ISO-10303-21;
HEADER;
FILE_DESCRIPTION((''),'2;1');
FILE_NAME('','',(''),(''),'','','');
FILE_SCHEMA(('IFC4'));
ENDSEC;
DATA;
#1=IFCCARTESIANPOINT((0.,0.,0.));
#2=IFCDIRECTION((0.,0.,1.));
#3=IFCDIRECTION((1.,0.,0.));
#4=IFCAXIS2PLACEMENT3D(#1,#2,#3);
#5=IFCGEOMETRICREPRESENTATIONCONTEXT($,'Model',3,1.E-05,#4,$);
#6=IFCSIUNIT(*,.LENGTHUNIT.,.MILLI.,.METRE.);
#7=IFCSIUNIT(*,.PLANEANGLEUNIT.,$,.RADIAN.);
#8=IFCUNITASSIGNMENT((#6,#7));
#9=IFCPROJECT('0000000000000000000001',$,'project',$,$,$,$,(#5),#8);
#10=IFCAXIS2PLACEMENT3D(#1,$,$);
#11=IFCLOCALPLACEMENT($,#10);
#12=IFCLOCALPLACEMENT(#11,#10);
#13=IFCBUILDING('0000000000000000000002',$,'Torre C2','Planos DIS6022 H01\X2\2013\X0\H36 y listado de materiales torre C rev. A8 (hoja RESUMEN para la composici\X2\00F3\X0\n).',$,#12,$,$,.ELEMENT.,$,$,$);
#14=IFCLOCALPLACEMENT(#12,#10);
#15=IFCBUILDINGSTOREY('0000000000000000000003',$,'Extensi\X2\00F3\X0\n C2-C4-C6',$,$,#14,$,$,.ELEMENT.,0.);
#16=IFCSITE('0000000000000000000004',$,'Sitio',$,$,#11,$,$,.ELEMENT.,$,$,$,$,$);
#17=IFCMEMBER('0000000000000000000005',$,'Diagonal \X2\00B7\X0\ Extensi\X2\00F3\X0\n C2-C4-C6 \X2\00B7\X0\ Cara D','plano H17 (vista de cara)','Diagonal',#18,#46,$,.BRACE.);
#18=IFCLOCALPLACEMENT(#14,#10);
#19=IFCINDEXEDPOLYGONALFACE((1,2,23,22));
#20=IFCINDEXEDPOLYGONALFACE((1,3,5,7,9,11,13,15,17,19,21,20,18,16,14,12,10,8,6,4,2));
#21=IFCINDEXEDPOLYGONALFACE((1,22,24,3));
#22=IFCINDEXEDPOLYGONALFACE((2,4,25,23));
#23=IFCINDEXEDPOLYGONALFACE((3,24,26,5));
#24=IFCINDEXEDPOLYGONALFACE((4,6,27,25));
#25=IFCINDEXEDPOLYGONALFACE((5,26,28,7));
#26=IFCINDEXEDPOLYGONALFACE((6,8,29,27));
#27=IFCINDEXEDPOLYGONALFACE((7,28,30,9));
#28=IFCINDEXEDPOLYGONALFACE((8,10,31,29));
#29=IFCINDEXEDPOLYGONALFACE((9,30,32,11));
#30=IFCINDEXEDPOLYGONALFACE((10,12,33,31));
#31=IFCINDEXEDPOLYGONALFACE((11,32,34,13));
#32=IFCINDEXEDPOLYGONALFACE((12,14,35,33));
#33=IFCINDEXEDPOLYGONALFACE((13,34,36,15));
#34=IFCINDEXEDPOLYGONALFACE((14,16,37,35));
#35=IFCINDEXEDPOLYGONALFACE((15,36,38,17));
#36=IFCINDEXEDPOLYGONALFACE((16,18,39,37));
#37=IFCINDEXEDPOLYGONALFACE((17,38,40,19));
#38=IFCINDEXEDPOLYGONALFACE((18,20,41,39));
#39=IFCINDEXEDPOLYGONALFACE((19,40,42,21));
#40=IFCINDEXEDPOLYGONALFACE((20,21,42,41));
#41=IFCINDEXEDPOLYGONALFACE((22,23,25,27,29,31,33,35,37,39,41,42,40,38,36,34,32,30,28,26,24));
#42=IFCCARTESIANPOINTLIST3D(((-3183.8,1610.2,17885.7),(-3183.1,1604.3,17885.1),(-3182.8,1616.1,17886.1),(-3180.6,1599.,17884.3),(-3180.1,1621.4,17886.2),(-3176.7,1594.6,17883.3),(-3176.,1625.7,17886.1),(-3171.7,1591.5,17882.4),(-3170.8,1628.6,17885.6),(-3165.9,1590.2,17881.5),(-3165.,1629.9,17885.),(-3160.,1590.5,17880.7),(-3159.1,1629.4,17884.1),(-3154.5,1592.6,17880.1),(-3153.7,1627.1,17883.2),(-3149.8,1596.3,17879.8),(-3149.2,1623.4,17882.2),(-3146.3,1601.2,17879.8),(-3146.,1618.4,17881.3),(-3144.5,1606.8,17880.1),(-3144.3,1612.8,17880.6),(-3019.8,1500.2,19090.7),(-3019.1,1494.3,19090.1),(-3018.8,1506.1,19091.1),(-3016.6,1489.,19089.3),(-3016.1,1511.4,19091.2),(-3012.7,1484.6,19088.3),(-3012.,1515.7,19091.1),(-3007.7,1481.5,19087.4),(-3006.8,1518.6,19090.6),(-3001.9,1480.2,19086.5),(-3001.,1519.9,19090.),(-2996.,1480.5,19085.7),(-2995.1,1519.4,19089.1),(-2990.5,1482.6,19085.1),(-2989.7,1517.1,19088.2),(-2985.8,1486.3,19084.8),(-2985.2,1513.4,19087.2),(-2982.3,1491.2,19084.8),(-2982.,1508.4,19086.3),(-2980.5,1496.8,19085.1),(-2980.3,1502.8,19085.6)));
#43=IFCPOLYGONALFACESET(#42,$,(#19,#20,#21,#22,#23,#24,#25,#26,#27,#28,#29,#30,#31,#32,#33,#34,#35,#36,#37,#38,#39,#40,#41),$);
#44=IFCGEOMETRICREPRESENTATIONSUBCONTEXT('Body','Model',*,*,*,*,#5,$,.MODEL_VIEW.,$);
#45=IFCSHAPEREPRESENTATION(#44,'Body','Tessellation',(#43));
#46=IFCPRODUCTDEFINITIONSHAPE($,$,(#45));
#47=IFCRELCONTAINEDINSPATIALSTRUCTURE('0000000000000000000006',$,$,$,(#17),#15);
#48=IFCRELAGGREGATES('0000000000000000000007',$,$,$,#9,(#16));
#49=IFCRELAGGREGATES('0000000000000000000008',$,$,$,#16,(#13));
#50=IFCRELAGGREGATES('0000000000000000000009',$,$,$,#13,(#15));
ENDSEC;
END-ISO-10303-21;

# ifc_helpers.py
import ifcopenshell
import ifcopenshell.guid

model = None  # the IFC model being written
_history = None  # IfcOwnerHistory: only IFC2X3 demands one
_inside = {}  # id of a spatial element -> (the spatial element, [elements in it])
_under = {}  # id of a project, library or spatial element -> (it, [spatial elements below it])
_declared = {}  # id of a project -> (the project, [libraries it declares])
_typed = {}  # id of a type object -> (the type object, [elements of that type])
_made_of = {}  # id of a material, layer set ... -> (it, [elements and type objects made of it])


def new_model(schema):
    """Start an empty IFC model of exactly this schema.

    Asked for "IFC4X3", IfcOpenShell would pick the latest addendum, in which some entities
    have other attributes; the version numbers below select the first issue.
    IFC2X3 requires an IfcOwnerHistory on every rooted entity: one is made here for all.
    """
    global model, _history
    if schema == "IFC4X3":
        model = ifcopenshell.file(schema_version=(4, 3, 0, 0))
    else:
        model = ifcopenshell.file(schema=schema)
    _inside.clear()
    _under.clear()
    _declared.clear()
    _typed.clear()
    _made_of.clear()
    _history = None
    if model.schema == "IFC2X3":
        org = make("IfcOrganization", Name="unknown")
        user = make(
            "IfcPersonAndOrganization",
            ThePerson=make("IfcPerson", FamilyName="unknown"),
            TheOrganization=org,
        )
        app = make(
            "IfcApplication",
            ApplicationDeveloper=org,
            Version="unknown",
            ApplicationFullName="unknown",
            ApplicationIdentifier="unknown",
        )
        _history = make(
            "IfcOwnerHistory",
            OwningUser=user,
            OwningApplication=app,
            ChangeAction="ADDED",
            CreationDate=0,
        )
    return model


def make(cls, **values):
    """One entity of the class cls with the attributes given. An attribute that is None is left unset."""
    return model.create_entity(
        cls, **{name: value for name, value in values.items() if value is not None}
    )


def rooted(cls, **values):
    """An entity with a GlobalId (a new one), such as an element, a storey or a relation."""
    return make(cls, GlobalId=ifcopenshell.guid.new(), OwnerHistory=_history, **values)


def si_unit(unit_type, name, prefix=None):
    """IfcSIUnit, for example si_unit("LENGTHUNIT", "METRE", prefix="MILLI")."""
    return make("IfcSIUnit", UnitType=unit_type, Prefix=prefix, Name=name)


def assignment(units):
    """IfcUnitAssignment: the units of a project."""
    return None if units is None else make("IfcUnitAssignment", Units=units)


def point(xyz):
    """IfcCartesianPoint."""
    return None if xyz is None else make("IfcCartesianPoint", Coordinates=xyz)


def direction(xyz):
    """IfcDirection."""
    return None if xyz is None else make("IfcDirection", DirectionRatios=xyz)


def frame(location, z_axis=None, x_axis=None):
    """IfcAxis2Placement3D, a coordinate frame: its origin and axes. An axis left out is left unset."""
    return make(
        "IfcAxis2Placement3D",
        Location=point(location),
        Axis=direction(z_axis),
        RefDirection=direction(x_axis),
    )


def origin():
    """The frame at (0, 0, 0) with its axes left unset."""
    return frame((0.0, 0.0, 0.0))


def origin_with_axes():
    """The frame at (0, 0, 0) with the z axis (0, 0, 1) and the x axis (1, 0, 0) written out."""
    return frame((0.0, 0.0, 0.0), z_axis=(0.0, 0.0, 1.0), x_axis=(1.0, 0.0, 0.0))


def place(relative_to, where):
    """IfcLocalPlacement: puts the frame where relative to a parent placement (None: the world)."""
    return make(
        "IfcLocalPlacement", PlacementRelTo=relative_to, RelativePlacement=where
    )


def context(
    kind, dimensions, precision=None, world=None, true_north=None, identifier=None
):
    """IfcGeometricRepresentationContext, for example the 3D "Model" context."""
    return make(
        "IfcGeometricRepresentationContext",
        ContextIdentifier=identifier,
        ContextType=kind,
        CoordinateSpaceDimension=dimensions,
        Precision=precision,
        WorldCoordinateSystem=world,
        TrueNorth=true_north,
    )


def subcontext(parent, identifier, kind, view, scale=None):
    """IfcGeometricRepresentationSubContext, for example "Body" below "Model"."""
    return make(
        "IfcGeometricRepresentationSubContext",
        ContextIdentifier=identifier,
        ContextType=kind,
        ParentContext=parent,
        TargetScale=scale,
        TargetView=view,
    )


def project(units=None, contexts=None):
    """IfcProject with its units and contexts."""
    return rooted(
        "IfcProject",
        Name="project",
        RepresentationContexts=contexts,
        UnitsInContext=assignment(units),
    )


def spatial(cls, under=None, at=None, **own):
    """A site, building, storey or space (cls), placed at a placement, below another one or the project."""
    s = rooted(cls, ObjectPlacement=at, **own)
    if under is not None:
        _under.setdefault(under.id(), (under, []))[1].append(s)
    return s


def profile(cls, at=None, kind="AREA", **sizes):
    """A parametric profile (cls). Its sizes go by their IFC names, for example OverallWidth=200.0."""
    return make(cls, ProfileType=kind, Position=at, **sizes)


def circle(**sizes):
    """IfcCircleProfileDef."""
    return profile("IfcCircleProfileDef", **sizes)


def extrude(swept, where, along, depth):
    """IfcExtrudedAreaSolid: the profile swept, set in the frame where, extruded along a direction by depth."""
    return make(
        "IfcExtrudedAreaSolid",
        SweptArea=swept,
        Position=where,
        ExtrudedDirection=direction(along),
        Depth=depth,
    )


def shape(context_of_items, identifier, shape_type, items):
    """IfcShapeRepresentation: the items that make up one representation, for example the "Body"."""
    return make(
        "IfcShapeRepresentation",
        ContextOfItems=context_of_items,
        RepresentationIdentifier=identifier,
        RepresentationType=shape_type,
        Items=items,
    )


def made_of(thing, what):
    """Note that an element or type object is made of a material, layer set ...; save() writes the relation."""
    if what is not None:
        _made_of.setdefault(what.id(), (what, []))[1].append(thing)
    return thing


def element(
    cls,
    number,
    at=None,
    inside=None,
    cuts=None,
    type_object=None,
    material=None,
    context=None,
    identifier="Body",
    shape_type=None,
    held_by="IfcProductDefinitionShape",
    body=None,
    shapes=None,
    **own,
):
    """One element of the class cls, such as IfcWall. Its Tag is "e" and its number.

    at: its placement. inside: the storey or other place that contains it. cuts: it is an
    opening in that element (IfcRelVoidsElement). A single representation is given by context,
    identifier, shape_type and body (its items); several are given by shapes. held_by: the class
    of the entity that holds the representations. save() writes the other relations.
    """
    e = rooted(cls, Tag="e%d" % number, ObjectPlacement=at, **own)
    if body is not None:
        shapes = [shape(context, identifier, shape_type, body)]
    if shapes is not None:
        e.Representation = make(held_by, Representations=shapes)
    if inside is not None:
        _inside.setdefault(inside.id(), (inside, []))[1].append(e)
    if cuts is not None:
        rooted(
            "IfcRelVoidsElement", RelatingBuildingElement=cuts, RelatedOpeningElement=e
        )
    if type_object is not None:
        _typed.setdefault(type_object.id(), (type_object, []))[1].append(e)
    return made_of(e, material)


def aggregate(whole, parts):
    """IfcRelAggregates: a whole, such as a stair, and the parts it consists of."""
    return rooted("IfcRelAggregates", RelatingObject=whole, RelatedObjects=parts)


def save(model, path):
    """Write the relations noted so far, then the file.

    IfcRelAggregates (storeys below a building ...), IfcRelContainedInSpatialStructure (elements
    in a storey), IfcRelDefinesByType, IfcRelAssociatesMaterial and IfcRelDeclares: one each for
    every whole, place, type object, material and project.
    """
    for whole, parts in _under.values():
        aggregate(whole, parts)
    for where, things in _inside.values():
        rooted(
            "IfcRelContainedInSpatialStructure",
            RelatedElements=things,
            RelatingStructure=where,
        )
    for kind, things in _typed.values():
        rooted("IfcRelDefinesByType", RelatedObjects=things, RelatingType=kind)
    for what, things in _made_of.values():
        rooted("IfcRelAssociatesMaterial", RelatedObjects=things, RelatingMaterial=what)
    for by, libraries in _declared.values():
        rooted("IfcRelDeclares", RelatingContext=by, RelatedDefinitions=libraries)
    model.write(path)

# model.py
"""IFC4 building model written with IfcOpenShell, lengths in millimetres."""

from ifc_helpers import new_model, si_unit, frame, origin, origin_with_axes, place, context, subcontext, project, spatial, circle, extrude, element, save


model = new_model("IFC4")

# Units and contexts
model_context = context("Model", 3, precision=1e-05, world=origin_with_axes())
body_context = subcontext(model_context, "Body", "Model", "MODEL_VIEW")
ifc_project = project(units=[si_unit("LENGTHUNIT", "METRE", prefix="MILLI"), si_unit("PLANEANGLEUNIT", "RADIAN")], contexts=[model_context])

# Site, building, storey
site_placement = place(None, origin())
site = spatial("IfcSite", under=ifc_project, at=site_placement, Name="Sitio", CompositionType="ELEMENT")
building_placement = place(site_placement, origin())
building = spatial("IfcBuilding", under=site, at=building_placement, Name="Torre C2", Description="Planos DIS6022 H01–H36 y listado de materiales torre C rev. A8 (hoja RESUMEN para la composición).", CompositionType="ELEMENT")
storey_placement = place(building_placement, origin())
storey = spatial("IfcBuildingStorey", under=building, at=storey_placement, Name="Extensión C2-C4-C6", CompositionType="ELEMENT", Elevation=0.0)

# Member
member_1_placement = place(storey_placement, frame((-3000.0, 1500.0, 19088.0), z_axis=(-0.134308, 0.090085, -0.986836), x_axis=(0.882686, -0.441723, -0.160456)))
element("IfcMember", 1, at=member_1_placement, inside=storey, Name="Diagonal · Extensión C2-C4-C6 · Cara D", Description="plano H17 (vista de cara)", ObjectType="Diagonal", PredefinedType="BRACE", context=body_context, shape_type="SweptSolid", body=[
    extrude(circle(Radius=20.0), None, (0.0, 0.0, 1.0), 1221.1),
])

save(model, "model.ifc")
